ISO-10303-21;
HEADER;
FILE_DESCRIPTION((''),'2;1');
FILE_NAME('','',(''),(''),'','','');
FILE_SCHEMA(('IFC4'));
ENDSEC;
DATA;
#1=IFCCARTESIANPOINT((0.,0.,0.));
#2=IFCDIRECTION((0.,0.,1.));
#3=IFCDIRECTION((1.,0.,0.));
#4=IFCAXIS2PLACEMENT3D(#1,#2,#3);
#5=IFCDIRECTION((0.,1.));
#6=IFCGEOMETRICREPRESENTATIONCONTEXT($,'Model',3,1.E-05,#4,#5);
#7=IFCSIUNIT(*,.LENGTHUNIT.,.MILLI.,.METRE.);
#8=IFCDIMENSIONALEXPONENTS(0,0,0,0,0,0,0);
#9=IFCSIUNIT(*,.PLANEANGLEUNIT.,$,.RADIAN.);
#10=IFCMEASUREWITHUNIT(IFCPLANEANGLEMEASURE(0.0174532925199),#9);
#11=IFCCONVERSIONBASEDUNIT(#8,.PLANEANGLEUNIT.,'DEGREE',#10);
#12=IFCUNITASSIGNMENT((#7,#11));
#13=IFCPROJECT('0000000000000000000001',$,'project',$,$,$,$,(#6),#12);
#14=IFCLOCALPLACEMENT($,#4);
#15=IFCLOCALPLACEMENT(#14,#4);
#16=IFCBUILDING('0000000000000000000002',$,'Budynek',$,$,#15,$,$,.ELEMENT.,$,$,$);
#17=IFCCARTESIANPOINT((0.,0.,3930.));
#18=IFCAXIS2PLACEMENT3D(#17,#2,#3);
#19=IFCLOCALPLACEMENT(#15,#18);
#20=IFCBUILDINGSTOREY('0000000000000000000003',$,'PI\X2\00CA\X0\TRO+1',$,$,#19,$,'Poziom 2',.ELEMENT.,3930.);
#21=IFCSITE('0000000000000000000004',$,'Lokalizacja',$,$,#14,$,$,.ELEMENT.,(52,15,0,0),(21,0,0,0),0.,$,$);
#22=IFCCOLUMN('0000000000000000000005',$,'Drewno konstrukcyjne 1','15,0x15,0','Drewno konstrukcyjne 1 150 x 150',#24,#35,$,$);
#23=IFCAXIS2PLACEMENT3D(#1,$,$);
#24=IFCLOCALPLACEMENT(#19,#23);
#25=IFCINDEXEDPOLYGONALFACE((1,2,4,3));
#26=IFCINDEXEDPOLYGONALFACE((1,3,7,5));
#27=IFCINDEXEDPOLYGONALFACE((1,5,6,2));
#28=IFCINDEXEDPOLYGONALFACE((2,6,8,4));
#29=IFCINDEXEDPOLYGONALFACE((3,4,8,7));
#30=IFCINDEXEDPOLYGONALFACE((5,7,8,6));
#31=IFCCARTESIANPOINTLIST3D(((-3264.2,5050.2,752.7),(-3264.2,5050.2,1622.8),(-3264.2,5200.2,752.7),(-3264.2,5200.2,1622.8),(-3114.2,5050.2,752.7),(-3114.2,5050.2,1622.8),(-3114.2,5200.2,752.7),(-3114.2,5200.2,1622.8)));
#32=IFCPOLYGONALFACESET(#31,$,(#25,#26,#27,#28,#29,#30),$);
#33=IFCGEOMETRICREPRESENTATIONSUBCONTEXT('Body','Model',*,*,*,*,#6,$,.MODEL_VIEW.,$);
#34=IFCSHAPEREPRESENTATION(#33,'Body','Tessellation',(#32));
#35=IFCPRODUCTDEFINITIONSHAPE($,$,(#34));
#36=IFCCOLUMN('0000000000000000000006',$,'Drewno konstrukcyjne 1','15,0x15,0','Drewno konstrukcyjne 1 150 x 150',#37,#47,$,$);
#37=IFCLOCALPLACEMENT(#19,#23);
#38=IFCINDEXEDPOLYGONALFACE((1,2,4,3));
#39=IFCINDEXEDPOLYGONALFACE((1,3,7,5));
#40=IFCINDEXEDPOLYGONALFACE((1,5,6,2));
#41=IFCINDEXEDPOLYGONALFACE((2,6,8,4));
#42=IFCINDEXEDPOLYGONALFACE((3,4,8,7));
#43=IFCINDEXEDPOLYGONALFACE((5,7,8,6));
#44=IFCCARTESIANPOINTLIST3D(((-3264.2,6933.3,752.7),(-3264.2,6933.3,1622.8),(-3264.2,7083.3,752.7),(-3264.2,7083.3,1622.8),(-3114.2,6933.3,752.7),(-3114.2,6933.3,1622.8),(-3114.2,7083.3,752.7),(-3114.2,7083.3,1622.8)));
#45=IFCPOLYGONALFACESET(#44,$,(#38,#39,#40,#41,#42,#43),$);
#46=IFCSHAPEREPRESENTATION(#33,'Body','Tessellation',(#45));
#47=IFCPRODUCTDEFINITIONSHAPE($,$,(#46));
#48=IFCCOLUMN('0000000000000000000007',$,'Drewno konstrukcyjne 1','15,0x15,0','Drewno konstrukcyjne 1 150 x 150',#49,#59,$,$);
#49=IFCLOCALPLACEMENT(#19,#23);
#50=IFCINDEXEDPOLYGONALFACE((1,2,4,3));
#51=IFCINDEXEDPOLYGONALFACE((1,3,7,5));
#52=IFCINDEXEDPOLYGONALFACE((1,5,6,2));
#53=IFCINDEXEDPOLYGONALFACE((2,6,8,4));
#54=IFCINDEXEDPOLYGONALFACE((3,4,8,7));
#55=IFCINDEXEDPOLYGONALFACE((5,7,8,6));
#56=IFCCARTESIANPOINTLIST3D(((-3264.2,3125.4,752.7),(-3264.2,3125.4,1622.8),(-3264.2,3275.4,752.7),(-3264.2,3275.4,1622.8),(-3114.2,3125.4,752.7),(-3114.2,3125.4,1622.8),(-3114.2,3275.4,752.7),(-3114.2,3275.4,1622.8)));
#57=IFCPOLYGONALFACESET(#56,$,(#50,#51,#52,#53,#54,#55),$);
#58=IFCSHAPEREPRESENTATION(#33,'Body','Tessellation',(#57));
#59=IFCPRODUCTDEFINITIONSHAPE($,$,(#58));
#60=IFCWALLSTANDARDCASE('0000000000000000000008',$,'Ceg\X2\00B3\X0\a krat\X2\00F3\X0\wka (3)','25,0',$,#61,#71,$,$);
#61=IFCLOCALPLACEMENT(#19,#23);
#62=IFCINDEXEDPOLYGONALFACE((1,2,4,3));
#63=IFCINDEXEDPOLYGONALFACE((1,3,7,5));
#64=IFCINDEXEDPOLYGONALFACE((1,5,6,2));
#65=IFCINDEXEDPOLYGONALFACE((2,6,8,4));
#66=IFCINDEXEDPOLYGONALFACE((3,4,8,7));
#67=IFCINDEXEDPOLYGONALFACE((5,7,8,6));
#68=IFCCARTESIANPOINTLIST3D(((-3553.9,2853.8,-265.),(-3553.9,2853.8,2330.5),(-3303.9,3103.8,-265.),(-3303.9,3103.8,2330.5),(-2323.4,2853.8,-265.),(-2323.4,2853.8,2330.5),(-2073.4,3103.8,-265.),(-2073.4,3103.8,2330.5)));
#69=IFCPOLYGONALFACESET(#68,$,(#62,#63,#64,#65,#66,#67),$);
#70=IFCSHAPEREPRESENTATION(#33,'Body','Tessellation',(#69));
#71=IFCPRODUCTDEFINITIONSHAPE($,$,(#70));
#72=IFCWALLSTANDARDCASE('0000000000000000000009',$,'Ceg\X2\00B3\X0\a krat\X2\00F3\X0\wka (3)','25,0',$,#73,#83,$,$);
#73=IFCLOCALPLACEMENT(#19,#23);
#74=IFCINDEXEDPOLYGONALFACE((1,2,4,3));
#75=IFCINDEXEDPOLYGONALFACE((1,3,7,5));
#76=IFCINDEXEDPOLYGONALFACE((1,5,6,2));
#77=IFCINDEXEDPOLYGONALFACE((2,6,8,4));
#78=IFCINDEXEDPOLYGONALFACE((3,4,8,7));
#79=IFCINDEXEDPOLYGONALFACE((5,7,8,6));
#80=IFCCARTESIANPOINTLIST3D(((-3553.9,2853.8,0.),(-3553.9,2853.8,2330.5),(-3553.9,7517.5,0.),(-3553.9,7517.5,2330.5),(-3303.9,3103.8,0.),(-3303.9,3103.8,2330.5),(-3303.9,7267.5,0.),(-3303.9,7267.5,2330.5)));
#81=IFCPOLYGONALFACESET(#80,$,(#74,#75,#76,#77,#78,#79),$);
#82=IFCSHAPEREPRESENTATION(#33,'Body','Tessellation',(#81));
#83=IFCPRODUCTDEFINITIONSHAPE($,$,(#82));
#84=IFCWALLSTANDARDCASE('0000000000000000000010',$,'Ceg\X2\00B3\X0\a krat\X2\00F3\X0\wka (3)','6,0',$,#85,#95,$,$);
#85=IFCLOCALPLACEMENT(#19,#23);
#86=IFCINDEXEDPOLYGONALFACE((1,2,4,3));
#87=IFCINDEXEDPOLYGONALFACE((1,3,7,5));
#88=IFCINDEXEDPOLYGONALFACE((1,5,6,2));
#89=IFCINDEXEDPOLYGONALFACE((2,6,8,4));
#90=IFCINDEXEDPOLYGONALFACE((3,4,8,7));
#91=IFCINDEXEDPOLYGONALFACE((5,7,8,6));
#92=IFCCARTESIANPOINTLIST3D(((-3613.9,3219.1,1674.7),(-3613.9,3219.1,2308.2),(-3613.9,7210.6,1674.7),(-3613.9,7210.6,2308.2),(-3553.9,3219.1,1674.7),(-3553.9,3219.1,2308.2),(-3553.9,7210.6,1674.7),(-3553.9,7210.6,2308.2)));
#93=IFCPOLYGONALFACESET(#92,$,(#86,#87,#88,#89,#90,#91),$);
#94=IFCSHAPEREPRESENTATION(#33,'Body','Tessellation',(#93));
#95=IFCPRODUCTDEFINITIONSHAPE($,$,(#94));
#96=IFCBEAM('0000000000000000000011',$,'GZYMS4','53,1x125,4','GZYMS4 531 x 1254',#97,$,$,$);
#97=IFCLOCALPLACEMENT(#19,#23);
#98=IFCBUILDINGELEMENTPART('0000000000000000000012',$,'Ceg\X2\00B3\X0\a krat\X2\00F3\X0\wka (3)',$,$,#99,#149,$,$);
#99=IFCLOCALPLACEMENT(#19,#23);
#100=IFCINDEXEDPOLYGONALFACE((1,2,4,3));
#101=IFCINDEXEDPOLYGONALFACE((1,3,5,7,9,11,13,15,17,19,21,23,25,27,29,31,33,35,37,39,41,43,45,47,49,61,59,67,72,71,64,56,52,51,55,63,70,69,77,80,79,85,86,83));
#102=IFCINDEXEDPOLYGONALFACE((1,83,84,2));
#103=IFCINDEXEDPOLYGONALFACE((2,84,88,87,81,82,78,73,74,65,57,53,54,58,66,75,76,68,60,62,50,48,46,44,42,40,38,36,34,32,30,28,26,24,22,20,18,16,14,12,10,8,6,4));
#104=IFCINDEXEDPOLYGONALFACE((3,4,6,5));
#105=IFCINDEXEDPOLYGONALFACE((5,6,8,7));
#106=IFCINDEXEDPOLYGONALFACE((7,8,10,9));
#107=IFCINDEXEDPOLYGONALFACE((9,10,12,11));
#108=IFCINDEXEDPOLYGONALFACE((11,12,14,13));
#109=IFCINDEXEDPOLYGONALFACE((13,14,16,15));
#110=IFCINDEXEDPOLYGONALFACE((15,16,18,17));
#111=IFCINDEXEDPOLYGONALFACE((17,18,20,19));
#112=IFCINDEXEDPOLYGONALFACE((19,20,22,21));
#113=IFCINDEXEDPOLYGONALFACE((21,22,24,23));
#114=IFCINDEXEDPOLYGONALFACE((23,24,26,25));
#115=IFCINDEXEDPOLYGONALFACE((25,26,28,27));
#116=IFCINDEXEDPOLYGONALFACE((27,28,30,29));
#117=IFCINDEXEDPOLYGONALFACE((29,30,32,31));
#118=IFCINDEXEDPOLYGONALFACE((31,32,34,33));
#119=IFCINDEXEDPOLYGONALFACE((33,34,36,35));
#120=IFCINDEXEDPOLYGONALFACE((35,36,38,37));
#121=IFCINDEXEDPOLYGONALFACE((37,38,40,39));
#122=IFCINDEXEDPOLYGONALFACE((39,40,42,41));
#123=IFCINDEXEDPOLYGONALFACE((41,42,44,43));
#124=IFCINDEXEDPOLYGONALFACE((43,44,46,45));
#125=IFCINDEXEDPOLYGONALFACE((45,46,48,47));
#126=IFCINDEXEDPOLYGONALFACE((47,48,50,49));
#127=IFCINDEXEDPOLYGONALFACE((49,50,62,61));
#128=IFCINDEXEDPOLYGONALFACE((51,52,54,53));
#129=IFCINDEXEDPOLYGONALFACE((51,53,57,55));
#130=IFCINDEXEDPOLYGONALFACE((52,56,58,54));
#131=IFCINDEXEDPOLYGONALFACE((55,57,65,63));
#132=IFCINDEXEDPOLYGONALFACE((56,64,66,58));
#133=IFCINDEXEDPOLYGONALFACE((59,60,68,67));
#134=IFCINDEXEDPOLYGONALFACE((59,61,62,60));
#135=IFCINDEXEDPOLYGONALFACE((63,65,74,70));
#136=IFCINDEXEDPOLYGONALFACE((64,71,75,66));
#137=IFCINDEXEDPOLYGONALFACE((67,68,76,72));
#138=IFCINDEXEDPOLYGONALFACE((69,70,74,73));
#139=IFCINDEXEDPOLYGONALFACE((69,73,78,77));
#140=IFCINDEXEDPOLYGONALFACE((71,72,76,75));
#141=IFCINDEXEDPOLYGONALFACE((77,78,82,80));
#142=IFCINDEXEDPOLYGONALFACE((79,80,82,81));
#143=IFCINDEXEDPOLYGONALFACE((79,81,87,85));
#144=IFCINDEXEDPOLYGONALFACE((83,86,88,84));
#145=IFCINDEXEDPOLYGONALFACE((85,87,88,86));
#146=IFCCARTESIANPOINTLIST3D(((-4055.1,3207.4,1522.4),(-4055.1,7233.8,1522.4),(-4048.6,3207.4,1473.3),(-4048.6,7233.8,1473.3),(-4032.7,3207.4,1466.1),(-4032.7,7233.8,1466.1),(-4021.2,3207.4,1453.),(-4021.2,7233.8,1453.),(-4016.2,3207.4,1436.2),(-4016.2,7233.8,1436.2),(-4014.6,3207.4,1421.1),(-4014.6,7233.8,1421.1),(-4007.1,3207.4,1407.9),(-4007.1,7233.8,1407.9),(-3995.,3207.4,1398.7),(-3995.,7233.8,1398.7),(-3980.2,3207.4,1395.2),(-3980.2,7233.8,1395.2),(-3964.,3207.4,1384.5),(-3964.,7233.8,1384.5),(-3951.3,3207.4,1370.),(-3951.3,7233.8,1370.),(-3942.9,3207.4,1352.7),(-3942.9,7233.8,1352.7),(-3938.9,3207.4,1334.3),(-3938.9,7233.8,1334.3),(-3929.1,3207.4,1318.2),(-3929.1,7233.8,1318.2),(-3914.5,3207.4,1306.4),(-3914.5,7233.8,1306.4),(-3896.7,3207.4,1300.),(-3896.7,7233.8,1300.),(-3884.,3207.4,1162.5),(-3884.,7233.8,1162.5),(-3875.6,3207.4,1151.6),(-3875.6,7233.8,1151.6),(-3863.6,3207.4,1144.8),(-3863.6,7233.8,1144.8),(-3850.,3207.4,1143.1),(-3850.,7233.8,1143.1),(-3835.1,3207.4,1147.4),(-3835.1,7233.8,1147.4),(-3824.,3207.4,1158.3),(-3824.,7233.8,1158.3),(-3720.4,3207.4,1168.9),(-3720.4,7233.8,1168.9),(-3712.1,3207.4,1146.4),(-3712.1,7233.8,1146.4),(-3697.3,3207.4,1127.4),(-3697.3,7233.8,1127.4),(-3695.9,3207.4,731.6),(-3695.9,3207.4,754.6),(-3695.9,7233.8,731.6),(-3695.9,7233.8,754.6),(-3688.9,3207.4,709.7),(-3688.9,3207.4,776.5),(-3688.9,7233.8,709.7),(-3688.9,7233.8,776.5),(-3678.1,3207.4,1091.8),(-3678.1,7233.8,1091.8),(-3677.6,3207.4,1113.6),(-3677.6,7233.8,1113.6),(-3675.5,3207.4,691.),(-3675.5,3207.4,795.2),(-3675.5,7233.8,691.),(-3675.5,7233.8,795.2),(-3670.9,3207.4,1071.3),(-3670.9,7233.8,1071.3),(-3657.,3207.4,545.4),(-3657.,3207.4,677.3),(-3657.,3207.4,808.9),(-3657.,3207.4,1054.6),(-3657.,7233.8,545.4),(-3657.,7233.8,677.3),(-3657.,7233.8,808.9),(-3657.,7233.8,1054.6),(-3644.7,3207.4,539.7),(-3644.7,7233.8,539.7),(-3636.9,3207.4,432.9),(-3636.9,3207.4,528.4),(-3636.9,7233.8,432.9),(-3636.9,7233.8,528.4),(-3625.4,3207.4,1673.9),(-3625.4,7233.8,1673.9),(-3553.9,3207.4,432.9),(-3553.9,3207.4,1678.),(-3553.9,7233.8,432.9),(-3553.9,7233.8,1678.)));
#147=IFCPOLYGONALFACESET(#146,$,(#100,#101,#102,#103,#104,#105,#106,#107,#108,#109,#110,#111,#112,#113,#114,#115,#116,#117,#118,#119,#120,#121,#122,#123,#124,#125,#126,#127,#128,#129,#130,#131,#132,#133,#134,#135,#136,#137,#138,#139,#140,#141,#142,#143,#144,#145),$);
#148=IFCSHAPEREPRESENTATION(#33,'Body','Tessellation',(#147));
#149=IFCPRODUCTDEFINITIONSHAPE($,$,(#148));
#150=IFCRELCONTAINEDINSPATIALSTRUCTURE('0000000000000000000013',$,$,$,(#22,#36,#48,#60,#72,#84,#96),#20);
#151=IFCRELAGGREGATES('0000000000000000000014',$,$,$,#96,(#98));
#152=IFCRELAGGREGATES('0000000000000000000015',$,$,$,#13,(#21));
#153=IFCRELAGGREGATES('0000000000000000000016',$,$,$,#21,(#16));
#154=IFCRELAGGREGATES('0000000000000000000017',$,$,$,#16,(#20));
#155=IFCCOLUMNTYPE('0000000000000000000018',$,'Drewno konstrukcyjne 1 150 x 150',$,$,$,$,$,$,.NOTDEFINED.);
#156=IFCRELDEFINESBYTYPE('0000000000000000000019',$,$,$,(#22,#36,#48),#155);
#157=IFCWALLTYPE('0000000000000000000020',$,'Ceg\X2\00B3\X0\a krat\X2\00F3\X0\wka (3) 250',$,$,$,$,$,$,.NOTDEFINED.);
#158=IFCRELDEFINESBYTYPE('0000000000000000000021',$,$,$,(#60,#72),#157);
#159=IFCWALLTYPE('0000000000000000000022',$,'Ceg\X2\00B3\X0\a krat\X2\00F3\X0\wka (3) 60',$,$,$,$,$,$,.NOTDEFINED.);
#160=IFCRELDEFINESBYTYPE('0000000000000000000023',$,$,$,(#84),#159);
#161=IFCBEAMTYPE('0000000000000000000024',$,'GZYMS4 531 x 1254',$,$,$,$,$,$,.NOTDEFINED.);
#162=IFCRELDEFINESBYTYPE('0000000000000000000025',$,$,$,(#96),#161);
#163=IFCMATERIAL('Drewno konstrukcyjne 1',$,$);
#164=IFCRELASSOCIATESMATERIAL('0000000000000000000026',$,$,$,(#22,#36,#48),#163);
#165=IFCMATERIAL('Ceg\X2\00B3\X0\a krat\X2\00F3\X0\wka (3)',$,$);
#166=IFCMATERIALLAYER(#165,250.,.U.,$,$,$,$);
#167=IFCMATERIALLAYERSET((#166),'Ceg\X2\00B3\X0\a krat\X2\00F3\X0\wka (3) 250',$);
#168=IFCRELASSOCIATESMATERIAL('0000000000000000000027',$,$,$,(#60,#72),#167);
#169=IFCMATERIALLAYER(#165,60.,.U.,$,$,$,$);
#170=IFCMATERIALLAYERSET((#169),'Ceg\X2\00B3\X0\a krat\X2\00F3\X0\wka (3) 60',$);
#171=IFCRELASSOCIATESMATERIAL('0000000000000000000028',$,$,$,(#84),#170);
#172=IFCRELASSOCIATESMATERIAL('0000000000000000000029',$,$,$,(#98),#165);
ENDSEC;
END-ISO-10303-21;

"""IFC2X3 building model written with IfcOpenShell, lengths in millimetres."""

from ifc_helpers import new_model, entity, si_unit, converted_unit, direction, frame, origin_with_axes, origin_2d_with_axis, place, context, subcontext, project, spatial, polyline, rectangle, outline, extrude, material, layer, layer_set, layer_usage, type_object, element, aggregate, save


model = new_model("IFC2X3")

# Units and contexts
model_context = context("Model", 3, precision=1e-05, world=origin_with_axes(), true_north=direction((0.0, 1.0)))
body_context = subcontext(model_context, "Body", "Model", "MODEL_VIEW")
ifc_project = project(units=[si_unit("LENGTHUNIT", "METRE", prefix="MILLI"), converted_unit("PLANEANGLEUNIT", "DEGREE", entity("IfcPlaneAngleMeasure", 0.0174532925199), si_unit("PLANEANGLEUNIT", "RADIAN"), dimensions=[0, 0, 0, 0, 0, 0, 0])], contexts=[model_context])

# Site, building, storey
site_placement = place(None, origin_with_axes())
site = spatial("IfcSite", under=ifc_project, at=site_placement, Name="Lokalizacja", CompositionType="ELEMENT", RefLatitude=(52, 15, 0, 0), RefLongitude=(21, 0, 0, 0), RefElevation=0.0)
building_placement = place(site_placement, origin_with_axes())
building = spatial("IfcBuilding", under=site, at=building_placement, Name="Budynek", CompositionType="ELEMENT")
storey_placement = place(building_placement, frame((0.0, 0.0, 3930.0), z_axis=(0.0, 0.0, 1.0), x_axis=(1.0, 0.0, 0.0)))
storey = spatial("IfcBuildingStorey", under=building, at=storey_placement, Name="PIÊTRO+1", LongName="Poziom 2", CompositionType="ELEMENT", Elevation=3930.0)

# Columns
ifc_material_1 = material(Name="Drewno konstrukcyjne 1")
column_type = type_object("IfcColumnType", Name="Drewno konstrukcyjne 1 150 x 150", PredefinedType="NOTDEFINED")
for number, where, z_axis, x_axis, name in (
    (1, (-3189.2, 5125.2, 752.7), (0.0, 0.0, 1.0), (0.0, -1.0, 0.0), "Drewno konstrukcyjne 1"),
    (2, (-3189.2, 7008.3, 752.7), (0.0, 0.0, 1.0), (-1.0, 0.0, 0.0), "Drewno konstrukcyjne 1"),
    (3, (-3189.2, 3200.4, 752.7), (0.0, 0.0, 1.0), (1.0, 0.0, 0.0), "Drewno konstrukcyjne 1"),
):
    element("IfcColumn", number, at=place(storey_placement, frame(where, z_axis=z_axis, x_axis=x_axis)), inside=storey, type_object=column_type, material=ifc_material_1, Name=name, Description="15,0x15,0", ObjectType="Drewno konstrukcyjne 1 150 x 150", context=body_context, shape_type="SweptSolid", body=[
        extrude(rectangle(XDim=150.0, YDim=150.0, at=origin_2d_with_axis()), origin_with_axes(), (0.0, 0.0, 1.0), 870.1),
    ])

# Walls
ifc_material_2 = material(Name="Ceg³a kratówka (3)")
ifc_layer_1 = layer(ifc_material_2, 250.0, ventilated="UNKNOWN")
ifc_layer_set_1 = layer_set([ifc_layer_1], Name="Ceg³a kratówka (3) 250")
ifc_layer_usage_1 = layer_usage(ifc_layer_set_1, "AXIS2", "NEGATIVE", 0.0)
wall_type_1 = type_object("IfcWallType", Name="Ceg³a kratówka (3) 250", PredefinedType="NOTDEFINED")
wall_1_placement = place(storey_placement, frame((-3303.9, 3103.8, -265.0), z_axis=(0.0, 0.0, 1.0), x_axis=(1.0, 0.0, 0.0)))
element("IfcWallStandardCase", 4, at=wall_1_placement, inside=storey, type_object=wall_type_1, material=ifc_layer_usage_1, Name="Ceg³a kratówka (3)", Description="25,0", context=body_context, shape_type="SweptSolid", body=[
    extrude(outline(polyline([(-250.0, -250.0), (980.5, -250.0), (1230.5, 0.0), (0.0, 0.0), (-250.0, -250.0)])), origin_with_axes(), (0.0, 0.0, 1.0), 2595.6),
])
ifc_layer_usage_2 = layer_usage(ifc_layer_set_1, "AXIS2", "NEGATIVE", 0.0)
wall_2_placement = place(storey_placement, frame((-3303.9, 7267.5, 0.0), z_axis=(0.0, 0.0, 1.0), x_axis=(0.0, -1.0, 0.0)))
element("IfcWallStandardCase", 5, at=wall_2_placement, inside=storey, type_object=wall_type_1, material=ifc_layer_usage_2, Name="Ceg³a kratówka (3)", Description="25,0", context=body_context, shape_type="SweptSolid", body=[
    extrude(outline(polyline([(-250.0, -250.0), (4413.7, -250.0), (4163.7, 0.0), (0.0, 0.0), (-250.0, -250.0)])), origin_with_axes(), (0.0, 0.0, 1.0), 2330.5),
])
ifc_layer_2 = layer(ifc_material_2, 60.0, ventilated="UNKNOWN")
ifc_layer_set_2 = layer_set([ifc_layer_2], Name="Ceg³a kratówka (3) 60")
ifc_layer_usage_3 = layer_usage(ifc_layer_set_2, "AXIS2", "POSITIVE", 0.0)
wall_type_2 = type_object("IfcWallType", Name="Ceg³a kratówka (3) 60", PredefinedType="NOTDEFINED")
wall_3_placement = place(storey_placement, frame((-3553.9, 3219.1, 1674.7), z_axis=(0.0, 0.0, 1.0), x_axis=(0.0, 1.0, 0.0)))
element("IfcWallStandardCase", 6, at=wall_3_placement, inside=storey, type_object=wall_type_2, material=ifc_layer_usage_3, Name="Ceg³a kratówka (3)", Description="6,0", context=body_context, shape_type="SweptSolid", body=[
    extrude(outline(polyline([(0.0, 0.0), (3991.6, 0.0), (3991.6, 60.0), (0.0, 60.0), (0.0, 0.0)])), origin_with_axes(), (0.0, 0.0, 1.0), 633.5),
])

# Beam, building element part
beam_type_1 = type_object("IfcBeamType", Name="GZYMS4 531 x 1254", PredefinedType="NOTDEFINED")
beam_1_placement = place(storey_placement, frame((-3648.6, 7233.8, 432.9), z_axis=(0.0, 0.0, 1.0), x_axis=(-1.0, 0.0, 0.0)))
beam_1 = element("IfcBeam", 7, at=beam_1_placement, inside=storey, type_object=beam_type_1, Name="GZYMS4", Description="53,1x125,4", ObjectType="GZYMS4 531 x 1254")
building_element_part_1_placement = place(beam_1_placement, origin_with_axes())
building_element_part_1 = element("IfcBuildingElementPart", 8, at=building_element_part_1_placement, material=ifc_material_2, Name="Ceg³a kratówka (3)", context=body_context, shape_type="SweptSolid", body=[
    extrude(outline(polyline([(406.6, 1089.5), (-23.1, 1241.0), (-94.6, 1245.1), (-94.6, 0.0), (-11.6, 0.0), (-11.6, 95.5), (-3.9, 106.8), (8.5, 112.5), (8.5, 244.4), (26.9, 258.1), (40.3, 276.8), (47.3, 298.7), (47.3, 321.7), (40.3, 343.6), (26.9, 362.3), (8.5, 376.0), (8.5, 621.7), (22.4, 638.4), (29.5, 658.9), (29.1, 680.7), (48.8, 694.5), (63.5, 713.5), (71.9, 736.0), (175.4, 725.4), (186.5, 714.5), (201.5, 710.2), (215.1, 711.9), (227.0, 718.7), (235.4, 729.6), (248.2, 867.1), (265.9, 873.5), (280.5, 885.3), (290.4, 901.4), (294.3, 919.8), (302.7, 937.1), (315.5, 951.6), (331.6, 962.3), (346.4, 965.8), (358.5, 975.0), (366.0, 988.2), (367.6, 1003.3), (372.6, 1020.1), (384.2, 1033.2), (400.1, 1040.4), (406.6, 1089.5)])), frame((0.0, 4026.4, 0.0), z_axis=(0.0, -1.0, 0.0), x_axis=(1.0, 0.0, 0.0)), (0.0, 0.0, 1.0), 4026.4),
])
aggregate(beam_1, [building_element_part_1])

save(model, "model.ifc")
